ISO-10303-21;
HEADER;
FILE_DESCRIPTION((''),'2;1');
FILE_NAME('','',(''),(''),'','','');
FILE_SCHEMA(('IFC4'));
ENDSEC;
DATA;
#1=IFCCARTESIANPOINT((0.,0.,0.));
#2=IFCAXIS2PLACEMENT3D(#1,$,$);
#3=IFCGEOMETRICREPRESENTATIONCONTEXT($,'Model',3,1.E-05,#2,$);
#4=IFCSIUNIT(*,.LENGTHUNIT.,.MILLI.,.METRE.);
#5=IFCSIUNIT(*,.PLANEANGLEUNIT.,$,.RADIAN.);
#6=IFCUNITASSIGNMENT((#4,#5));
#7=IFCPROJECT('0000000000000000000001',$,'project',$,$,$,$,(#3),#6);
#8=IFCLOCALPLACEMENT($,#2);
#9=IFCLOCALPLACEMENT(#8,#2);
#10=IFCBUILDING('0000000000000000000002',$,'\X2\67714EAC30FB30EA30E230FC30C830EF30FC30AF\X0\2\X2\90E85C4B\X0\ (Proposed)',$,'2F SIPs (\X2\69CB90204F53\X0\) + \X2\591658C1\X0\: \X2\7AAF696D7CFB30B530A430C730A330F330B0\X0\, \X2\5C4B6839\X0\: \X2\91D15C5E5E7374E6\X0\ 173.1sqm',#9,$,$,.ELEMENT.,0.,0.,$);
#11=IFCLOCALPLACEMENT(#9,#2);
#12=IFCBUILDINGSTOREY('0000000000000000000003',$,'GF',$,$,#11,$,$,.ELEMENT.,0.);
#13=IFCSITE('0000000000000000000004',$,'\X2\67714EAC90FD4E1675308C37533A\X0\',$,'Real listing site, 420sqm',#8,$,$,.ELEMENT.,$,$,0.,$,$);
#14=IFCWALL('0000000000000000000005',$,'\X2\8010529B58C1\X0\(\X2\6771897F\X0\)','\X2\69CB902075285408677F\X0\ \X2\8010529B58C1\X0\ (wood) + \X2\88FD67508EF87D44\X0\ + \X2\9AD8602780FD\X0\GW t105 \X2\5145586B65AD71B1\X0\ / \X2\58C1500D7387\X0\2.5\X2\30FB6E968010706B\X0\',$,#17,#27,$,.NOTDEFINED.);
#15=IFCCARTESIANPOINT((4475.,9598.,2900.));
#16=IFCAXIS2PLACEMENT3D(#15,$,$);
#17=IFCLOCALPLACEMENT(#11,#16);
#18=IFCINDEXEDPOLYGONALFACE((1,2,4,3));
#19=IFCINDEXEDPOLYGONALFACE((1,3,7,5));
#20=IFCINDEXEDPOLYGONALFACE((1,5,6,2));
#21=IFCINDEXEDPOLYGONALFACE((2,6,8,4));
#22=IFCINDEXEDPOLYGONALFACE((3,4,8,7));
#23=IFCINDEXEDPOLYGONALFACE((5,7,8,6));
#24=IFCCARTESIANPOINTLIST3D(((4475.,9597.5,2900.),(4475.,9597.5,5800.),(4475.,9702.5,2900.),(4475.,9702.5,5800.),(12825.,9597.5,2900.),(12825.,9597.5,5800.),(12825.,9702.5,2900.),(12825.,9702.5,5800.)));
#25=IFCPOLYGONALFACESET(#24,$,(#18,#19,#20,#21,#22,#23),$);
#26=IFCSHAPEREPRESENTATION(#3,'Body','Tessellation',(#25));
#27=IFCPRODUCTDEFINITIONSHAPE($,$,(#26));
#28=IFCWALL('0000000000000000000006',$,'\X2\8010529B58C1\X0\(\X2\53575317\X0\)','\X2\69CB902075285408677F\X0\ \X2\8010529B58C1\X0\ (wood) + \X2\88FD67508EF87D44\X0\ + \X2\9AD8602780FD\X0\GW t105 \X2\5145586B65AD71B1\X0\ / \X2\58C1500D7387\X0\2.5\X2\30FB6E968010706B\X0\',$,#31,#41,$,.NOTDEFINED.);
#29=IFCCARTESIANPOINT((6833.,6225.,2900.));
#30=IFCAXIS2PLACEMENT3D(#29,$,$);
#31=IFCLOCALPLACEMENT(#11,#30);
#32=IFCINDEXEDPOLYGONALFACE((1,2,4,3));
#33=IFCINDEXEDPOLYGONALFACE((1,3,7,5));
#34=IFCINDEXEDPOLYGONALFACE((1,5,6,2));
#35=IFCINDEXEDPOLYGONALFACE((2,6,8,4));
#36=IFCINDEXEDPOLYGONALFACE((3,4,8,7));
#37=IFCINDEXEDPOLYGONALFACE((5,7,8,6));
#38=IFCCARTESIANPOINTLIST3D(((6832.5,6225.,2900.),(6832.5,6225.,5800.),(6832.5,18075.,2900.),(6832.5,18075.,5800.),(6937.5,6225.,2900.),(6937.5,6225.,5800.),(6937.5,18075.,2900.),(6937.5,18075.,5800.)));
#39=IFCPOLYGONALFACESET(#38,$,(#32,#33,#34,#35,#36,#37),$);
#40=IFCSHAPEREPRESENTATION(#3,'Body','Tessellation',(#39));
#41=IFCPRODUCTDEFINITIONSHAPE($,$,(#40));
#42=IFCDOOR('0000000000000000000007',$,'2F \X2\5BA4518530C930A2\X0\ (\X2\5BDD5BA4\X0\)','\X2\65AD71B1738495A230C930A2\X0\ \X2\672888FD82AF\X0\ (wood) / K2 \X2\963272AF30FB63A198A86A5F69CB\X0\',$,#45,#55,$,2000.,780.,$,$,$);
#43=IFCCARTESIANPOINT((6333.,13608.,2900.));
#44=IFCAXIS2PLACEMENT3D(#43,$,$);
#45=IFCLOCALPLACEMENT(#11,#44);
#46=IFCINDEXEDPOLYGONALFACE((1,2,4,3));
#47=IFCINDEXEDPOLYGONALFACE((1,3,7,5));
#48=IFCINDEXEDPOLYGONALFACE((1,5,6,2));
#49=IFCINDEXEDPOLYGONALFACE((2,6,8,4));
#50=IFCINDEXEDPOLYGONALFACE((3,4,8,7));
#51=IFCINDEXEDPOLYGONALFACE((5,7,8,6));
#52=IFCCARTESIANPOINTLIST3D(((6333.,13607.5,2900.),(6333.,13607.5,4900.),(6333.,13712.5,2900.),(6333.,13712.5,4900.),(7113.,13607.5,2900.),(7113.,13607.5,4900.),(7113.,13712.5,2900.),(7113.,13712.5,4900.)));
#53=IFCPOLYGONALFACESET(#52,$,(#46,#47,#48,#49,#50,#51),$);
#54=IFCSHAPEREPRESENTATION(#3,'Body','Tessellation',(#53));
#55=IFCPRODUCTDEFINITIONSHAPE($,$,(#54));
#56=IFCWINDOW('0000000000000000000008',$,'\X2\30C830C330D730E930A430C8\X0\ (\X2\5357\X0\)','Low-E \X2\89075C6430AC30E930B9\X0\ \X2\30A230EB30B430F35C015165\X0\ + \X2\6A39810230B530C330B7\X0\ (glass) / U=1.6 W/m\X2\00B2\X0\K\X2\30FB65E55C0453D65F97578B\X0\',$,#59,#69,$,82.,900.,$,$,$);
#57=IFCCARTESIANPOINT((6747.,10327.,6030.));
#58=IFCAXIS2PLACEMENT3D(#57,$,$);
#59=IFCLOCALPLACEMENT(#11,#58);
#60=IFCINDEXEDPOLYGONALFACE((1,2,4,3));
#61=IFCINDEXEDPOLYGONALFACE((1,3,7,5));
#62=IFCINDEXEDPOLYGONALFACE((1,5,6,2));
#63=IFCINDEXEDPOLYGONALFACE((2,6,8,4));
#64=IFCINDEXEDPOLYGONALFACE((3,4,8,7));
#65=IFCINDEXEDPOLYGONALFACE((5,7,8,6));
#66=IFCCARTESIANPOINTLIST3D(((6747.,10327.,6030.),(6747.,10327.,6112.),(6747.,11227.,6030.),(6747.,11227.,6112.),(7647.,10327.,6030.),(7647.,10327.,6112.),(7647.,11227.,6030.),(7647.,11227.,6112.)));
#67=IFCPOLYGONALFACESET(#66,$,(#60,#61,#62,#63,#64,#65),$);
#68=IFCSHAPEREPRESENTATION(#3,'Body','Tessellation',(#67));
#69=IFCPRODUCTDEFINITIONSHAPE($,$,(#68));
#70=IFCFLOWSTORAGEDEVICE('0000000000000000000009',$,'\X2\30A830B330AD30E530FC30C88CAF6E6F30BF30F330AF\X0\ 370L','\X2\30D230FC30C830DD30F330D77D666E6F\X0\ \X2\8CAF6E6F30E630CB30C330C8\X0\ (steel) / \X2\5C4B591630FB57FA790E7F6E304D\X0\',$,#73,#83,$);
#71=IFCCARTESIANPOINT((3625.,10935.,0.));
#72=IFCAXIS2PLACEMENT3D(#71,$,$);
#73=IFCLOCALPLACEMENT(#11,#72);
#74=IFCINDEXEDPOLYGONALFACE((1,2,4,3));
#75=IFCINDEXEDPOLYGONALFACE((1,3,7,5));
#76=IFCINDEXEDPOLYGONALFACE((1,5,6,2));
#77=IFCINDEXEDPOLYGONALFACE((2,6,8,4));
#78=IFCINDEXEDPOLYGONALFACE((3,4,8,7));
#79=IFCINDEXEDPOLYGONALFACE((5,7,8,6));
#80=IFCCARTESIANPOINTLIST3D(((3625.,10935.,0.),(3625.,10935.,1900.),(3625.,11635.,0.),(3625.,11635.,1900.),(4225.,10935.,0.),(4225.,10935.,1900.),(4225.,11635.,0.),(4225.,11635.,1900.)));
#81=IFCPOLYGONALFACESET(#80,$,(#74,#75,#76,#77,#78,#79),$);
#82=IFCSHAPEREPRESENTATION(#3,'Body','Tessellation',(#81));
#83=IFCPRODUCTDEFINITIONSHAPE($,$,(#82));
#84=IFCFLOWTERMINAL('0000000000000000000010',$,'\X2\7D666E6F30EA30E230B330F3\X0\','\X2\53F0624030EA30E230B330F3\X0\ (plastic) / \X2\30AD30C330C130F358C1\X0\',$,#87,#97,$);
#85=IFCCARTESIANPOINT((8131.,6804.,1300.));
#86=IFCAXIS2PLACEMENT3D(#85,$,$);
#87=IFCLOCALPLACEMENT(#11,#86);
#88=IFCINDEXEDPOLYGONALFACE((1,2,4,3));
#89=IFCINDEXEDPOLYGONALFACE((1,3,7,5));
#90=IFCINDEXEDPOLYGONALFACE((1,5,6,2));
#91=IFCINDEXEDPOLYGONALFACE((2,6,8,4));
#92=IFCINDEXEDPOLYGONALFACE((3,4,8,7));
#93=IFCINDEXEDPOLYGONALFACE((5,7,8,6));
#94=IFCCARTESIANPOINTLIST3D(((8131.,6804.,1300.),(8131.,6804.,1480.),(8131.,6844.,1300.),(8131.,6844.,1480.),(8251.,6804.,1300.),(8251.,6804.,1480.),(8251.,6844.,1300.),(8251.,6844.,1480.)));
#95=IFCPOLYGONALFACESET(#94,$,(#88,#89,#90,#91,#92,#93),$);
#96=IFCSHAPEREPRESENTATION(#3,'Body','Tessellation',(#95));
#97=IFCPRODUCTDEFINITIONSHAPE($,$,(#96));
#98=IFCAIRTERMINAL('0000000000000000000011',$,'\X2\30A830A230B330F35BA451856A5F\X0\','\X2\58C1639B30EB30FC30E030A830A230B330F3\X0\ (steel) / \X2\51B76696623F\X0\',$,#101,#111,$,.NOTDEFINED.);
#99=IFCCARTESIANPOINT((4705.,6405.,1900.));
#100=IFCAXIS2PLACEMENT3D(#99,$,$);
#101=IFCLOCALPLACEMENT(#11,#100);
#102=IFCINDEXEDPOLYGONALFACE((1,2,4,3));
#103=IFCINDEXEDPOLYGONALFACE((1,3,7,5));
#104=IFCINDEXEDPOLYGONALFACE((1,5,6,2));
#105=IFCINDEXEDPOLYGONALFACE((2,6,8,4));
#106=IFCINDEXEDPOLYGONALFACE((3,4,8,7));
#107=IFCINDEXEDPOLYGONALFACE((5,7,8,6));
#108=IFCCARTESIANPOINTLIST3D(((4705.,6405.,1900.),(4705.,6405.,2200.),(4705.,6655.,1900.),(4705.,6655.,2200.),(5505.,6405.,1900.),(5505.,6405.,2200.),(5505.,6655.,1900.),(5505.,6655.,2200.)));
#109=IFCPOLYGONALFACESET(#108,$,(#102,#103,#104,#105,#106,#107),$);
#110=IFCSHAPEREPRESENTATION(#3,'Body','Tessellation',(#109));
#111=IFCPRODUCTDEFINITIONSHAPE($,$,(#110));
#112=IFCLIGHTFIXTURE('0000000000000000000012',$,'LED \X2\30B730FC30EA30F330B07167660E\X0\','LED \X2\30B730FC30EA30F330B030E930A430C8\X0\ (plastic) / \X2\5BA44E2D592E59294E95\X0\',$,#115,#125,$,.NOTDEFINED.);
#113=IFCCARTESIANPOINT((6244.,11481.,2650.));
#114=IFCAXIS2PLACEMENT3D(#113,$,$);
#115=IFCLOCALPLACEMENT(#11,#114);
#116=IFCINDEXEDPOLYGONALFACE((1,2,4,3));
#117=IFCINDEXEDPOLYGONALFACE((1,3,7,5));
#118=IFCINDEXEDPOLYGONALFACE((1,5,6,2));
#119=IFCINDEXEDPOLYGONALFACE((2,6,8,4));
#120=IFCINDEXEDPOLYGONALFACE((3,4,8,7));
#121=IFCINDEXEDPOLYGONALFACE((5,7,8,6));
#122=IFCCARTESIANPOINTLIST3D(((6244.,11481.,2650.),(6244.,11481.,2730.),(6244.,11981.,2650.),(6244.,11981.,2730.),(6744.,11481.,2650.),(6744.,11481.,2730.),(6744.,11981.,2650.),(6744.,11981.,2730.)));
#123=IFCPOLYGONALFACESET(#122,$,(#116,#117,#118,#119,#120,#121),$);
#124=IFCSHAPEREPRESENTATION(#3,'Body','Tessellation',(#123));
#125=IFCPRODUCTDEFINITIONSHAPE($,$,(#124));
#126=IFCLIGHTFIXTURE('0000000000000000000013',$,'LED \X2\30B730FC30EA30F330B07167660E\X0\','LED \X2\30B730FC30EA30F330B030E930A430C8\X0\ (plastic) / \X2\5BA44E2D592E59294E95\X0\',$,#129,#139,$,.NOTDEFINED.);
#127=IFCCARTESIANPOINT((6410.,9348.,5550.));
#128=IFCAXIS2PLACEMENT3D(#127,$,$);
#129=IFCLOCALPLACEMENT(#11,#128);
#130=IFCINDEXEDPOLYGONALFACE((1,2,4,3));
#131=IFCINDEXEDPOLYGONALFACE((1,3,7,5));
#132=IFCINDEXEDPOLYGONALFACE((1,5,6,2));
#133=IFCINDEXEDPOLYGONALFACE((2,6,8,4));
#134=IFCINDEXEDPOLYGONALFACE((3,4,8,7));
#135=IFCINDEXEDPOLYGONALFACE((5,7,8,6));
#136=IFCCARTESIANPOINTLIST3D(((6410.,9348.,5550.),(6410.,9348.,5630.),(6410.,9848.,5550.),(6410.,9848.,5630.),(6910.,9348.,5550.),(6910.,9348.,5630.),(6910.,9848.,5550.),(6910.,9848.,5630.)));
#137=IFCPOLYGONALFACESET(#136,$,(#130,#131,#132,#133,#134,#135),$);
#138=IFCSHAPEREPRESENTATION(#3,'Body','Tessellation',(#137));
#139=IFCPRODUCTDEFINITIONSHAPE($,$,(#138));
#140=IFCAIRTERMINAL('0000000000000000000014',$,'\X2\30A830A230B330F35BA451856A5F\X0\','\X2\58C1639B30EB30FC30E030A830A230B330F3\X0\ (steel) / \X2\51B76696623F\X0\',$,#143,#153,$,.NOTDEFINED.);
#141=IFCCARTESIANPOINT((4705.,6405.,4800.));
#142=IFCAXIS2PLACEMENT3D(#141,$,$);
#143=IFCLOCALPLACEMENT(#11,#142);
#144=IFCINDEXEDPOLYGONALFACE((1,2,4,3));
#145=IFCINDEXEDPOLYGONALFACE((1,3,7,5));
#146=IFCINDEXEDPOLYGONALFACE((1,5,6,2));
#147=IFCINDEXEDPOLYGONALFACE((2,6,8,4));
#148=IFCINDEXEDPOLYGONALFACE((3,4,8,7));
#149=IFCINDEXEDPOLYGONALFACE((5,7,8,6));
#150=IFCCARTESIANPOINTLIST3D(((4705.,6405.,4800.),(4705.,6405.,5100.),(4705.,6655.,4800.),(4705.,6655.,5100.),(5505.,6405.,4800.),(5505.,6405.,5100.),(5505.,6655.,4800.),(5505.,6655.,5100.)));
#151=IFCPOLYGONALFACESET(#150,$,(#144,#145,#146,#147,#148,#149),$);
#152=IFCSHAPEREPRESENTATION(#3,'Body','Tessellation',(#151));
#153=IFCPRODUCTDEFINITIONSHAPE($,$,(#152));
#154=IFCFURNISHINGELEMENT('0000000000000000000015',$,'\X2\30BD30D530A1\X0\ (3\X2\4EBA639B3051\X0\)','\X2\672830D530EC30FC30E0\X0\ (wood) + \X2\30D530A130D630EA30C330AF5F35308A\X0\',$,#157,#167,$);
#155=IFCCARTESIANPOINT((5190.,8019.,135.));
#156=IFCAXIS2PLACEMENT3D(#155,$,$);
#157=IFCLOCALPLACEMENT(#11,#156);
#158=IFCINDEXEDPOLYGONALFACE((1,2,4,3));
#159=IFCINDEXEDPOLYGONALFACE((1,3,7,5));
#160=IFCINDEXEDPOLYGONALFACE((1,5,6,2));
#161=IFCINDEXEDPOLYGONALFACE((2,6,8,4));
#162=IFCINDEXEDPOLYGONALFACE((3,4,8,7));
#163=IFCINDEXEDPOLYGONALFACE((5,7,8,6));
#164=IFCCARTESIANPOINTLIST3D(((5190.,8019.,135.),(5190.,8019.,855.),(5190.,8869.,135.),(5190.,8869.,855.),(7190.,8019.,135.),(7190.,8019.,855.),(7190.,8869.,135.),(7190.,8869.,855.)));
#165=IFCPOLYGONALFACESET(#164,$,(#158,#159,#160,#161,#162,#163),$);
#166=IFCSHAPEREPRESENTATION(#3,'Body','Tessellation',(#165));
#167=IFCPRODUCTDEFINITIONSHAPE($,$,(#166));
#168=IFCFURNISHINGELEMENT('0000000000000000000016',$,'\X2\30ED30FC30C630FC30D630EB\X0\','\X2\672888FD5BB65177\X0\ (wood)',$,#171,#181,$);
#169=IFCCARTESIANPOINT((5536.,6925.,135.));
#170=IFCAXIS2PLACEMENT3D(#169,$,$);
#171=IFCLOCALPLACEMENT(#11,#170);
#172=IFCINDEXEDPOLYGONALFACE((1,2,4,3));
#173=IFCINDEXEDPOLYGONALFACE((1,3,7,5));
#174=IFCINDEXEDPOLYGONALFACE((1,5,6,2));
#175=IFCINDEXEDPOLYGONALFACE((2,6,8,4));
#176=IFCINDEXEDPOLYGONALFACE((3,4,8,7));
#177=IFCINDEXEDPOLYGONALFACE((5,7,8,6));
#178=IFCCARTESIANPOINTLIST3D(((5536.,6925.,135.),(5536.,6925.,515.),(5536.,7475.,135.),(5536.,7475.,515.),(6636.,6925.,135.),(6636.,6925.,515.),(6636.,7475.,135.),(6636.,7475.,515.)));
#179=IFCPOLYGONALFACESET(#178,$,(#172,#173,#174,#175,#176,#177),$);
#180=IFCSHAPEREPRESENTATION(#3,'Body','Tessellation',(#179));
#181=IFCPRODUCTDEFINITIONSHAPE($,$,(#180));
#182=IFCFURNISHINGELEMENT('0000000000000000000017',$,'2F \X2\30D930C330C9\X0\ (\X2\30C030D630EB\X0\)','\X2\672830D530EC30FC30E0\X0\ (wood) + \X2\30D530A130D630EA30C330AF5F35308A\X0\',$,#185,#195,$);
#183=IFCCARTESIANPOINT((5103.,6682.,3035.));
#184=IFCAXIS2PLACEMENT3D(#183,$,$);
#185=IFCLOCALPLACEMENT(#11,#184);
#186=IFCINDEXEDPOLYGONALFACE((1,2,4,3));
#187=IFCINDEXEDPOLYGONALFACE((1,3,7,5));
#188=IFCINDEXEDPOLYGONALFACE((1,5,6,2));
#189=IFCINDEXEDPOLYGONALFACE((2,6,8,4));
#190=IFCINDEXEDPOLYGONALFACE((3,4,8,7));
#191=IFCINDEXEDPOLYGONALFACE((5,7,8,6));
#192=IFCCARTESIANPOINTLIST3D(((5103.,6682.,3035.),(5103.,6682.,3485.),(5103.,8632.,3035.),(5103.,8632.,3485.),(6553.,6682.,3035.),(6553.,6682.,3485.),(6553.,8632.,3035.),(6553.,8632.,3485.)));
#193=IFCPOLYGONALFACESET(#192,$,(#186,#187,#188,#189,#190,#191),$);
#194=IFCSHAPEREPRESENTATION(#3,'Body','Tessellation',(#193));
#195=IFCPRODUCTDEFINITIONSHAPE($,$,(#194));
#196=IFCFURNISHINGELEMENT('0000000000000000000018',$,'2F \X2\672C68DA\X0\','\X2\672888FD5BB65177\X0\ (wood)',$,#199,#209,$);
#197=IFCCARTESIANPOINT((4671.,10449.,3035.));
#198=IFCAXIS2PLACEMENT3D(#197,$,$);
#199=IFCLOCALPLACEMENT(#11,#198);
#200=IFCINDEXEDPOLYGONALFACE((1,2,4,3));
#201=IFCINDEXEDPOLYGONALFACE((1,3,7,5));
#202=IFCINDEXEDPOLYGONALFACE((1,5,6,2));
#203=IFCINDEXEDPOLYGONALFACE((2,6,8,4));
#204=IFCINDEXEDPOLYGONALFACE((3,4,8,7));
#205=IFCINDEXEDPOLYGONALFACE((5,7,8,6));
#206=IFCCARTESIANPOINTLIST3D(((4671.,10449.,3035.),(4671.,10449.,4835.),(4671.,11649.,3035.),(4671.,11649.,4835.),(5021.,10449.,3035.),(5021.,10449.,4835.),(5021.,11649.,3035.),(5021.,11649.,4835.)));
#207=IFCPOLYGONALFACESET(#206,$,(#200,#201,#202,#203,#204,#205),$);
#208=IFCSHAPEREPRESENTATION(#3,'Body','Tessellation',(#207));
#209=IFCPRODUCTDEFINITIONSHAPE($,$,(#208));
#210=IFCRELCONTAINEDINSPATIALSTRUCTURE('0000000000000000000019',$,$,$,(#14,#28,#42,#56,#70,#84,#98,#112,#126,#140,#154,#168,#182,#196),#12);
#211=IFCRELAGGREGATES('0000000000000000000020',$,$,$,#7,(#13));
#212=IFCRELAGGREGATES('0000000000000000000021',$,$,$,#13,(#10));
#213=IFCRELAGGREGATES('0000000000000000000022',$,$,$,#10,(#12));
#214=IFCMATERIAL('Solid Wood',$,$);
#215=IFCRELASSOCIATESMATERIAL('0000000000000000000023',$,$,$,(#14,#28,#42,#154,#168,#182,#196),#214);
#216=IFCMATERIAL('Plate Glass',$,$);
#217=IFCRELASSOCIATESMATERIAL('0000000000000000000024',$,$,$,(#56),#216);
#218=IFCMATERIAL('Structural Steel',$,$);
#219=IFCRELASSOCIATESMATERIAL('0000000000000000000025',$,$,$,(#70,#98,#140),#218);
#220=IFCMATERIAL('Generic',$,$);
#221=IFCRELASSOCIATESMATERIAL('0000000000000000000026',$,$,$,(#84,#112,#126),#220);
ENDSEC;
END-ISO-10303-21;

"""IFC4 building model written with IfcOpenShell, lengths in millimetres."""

from ifc_helpers import new_model, si_unit, frame, frame_2d, origin, place, context, project, spatial, rectangle, extrude, material, element, fill, save


model = new_model("IFC4")

# Units and contexts
model_context = context("Model", 3, precision=1e-05, world=origin())
ifc_project = project(units=[si_unit("LENGTHUNIT", "METRE", prefix="MILLI"), si_unit("PLANEANGLEUNIT", "RADIAN")], contexts=[model_context])

# Site, building, storey
site_placement = place(None, origin())
site = spatial("IfcSite", under=ifc_project, at=site_placement, Name="東京都世田谷区", ObjectType="Real listing site, 420sqm", CompositionType="ELEMENT", RefElevation=0.0)
building_placement = place(site_placement, origin())
building = spatial("IfcBuilding", under=site, at=building_placement, Name="東京・リモートワーク2部屋 (Proposed)", ObjectType="2F SIPs (構造体) + 外壁: 窯業系サイディング, 屋根: 金属平瓦 173.1sqm", CompositionType="ELEMENT", ElevationOfRefHeight=0.0, ElevationOfTerrain=0.0)
storey_placement = place(building_placement, origin())
storey = spatial("IfcBuildingStorey", under=building, at=storey_placement, Name="GF", CompositionType="ELEMENT", Elevation=0.0)

# Shared definitions
ifc_material_1 = material(Name="Solid Wood")

# Wall
wall_1_placement = place(storey_placement, frame((4475.0, 9598.0, 2900.0)))
element("IfcWall", 1, at=wall_1_placement, inside=storey, material=ifc_material_1, Name="耐力壁(東西)", Description="構造用合板 耐力壁 (wood) + 製材軸組 + 高性能GW t105 充填断熱 / 壁倍率2.5・準耐火", PredefinedType="NOTDEFINED", context=model_context, shape_type="SweptSolid", body=[
    extrude(rectangle(XDim=8350.0, YDim=105.0, at=frame_2d((4175.0, 52.0))), frame((4475.0, 9598.0, 2900.0)), (0.0, 0.0, 1.0), 2900.0),
])

# Wall, opening, door
wall_2_placement = place(storey_placement, frame((6833.0, 6225.0, 2900.0)))
wall_2 = element("IfcWall", 2, at=wall_2_placement, inside=storey, material=ifc_material_1, Name="耐力壁(南北)", Description="構造用合板 耐力壁 (wood) + 製材軸組 + 高性能GW t105 充填断熱 / 壁倍率2.5・準耐火", PredefinedType="NOTDEFINED", context=model_context, shape_type="SweptSolid", body=[
    extrude(rectangle(XDim=105.0, YDim=11850.0, at=frame_2d((52.0, 5925.0))), frame((6833.0, 6225.0, 2900.0)), (0.0, 0.0, 1.0), 2900.0),
])
opening_placement = place(storey_placement, frame((6333.0, 13608.0, 2900.0)))
opening = element("IfcOpeningElement", 3, at=opening_placement, cuts=wall_2, PredefinedType="NOTDEFINED", context=model_context, shape_type="SweptSolid", body=[
    extrude(rectangle(XDim=780.0, YDim=105.0, at=frame_2d((390.0, 52.0))), frame((6333.0, 13608.0, 2900.0)), (0.0, 0.0, 1.0), 2000.0),
])
door_placement = place(storey_placement, frame((6333.0, 13608.0, 2900.0)))
door = element("IfcDoor", 4, at=door_placement, inside=storey, material=ifc_material_1, Name="2F 室内ドア (寝室)", Description="断熱玄関ドア 木製芯 (wood) / K2 防犯・採風機構", OverallHeight=2000.0, OverallWidth=780.0, context=model_context, shape_type="SweptSolid", body=[
    extrude(rectangle(XDim=780.0, YDim=105.0, at=frame_2d((390.0, 52.0))), frame((6333.0, 13608.0, 2900.0)), (0.0, 0.0, 1.0), 2000.0),
])
fill(opening, door)

# Window
ifc_material_2 = material(Name="Plate Glass")
window_placement = place(storey_placement, frame((6747.0, 10327.0, 6030.0)))
element("IfcWindow", 5, at=window_placement, inside=storey, material=ifc_material_2, Name="トップライト (南)", Description="Low-E 複層ガラス アルゴン封入 + 樹脂サッシ (glass) / U=1.6 W/m²K・日射取得型", OverallHeight=82.0, OverallWidth=900.0, context=model_context, shape_type="SweptSolid", body=[
    extrude(rectangle(XDim=900.0, YDim=900.0, at=frame_2d((450.0, 450.0))), frame((6747.0, 10327.0, 6030.0)), (0.0, 0.0, 1.0), 82.0),
])

# Flow storage device
ifc_material_3 = material(Name="Structural Steel")
flow_storage_device_placement = place(storey_placement, frame((3625.0, 10935.0, 0.0)))
element("IfcFlowStorageDevice", 6, at=flow_storage_device_placement, inside=storey, material=ifc_material_3, Name="エコキュート貯湯タンク 370L", Description="ヒートポンプ給湯 貯湯ユニット (steel) / 屋外・基礎置き", context=model_context, shape_type="SweptSolid", body=[
    extrude(rectangle(XDim=600.0, YDim=700.0, at=frame_2d((300.0, 350.0))), frame((3625.0, 10935.0, 0.0)), (0.0, 0.0, 1.0), 1900.0),
])

# Flow terminal
ifc_material_4 = material(Name="Generic")
flow_terminal_placement = place(storey_placement, frame((8131.0, 6804.0, 1300.0)))
element("IfcFlowTerminal", 7, at=flow_terminal_placement, inside=storey, material=ifc_material_4, Name="給湯リモコン", Description="台所リモコン (plastic) / キッチン壁", context=model_context, shape_type="SweptSolid", body=[
    extrude(rectangle(XDim=120.0, YDim=40.0, at=frame_2d((60.0, 20.0))), frame((8131.0, 6804.0, 1300.0)), (0.0, 0.0, 1.0), 180.0),
])

# Air terminal
air_terminal_1_placement = place(storey_placement, frame((4705.0, 6405.0, 1900.0)))
element("IfcAirTerminal", 8, at=air_terminal_1_placement, inside=storey, material=ifc_material_3, Name="エアコン室内機", Description="壁掛ルームエアコン (steel) / 冷暖房", PredefinedType="NOTDEFINED", context=model_context, shape_type="SweptSolid", body=[
    extrude(rectangle(XDim=800.0, YDim=250.0, at=frame_2d((400.0, 125.0))), frame((4705.0, 6405.0, 1900.0)), (0.0, 0.0, 1.0), 300.0),
])

# Light fixtures
light_fixture_1_placement = place(storey_placement, frame((6244.0, 11481.0, 2650.0)))
element("IfcLightFixture", 9, at=light_fixture_1_placement, inside=storey, material=ifc_material_4, Name="LED シーリング照明", Description="LED シーリングライト (plastic) / 室中央天井", PredefinedType="NOTDEFINED", context=model_context, shape_type="SweptSolid", body=[
    extrude(rectangle(XDim=500.0, YDim=500.0, at=frame_2d((250.0, 250.0))), frame((6244.0, 11481.0, 2650.0)), (0.0, 0.0, 1.0), 80.0),
])
light_fixture_2_placement = place(storey_placement, frame((6410.0, 9348.0, 5550.0)))
element("IfcLightFixture", 10, at=light_fixture_2_placement, inside=storey, material=ifc_material_4, Name="LED シーリング照明", Description="LED シーリングライト (plastic) / 室中央天井", PredefinedType="NOTDEFINED", context=model_context, shape_type="SweptSolid", body=[
    extrude(rectangle(XDim=500.0, YDim=500.0, at=frame_2d((250.0, 250.0))), frame((6410.0, 9348.0, 5550.0)), (0.0, 0.0, 1.0), 80.0),
])

# Air terminal
air_terminal_2_placement = place(storey_placement, frame((4705.0, 6405.0, 4800.0)))
element("IfcAirTerminal", 11, at=air_terminal_2_placement, inside=storey, material=ifc_material_3, Name="エアコン室内機", Description="壁掛ルームエアコン (steel) / 冷暖房", PredefinedType="NOTDEFINED", context=model_context, shape_type="SweptSolid", body=[
    extrude(rectangle(XDim=800.0, YDim=250.0, at=frame_2d((400.0, 125.0))), frame((4705.0, 6405.0, 4800.0)), (0.0, 0.0, 1.0), 300.0),
])

# Furnishing elements
furnishing_1_placement = place(storey_placement, frame((5190.0, 8019.0, 135.0)))
element("IfcFurnishingElement", 12, at=furnishing_1_placement, inside=storey, material=ifc_material_1, Name="ソファ (3人掛け)", Description="木フレーム (wood) + ファブリック張り", context=model_context, shape_type="SweptSolid", body=[
    extrude(rectangle(XDim=2000.0, YDim=850.0, at=frame_2d((1000.0, 425.0))), frame((5190.0, 8019.0, 135.0)), (0.0, 0.0, 1.0), 720.0),
])
furnishing_2_placement = place(storey_placement, frame((5536.0, 6925.0, 135.0)))
element("IfcFurnishingElement", 13, at=furnishing_2_placement, inside=storey, material=ifc_material_1, Name="ローテーブル", Description="木製家具 (wood)", context=model_context, shape_type="SweptSolid", body=[
    extrude(rectangle(XDim=1100.0, YDim=550.0, at=frame_2d((550.0, 275.0))), frame((5536.0, 6925.0, 135.0)), (0.0, 0.0, 1.0), 380.0),
])
furnishing_3_placement = place(storey_placement, frame((5103.0, 6682.0, 3035.0)))
element("IfcFurnishingElement", 14, at=furnishing_3_placement, inside=storey, material=ifc_material_1, Name="2F ベッド (ダブル)", Description="木フレーム (wood) + ファブリック張り", context=model_context, shape_type="SweptSolid", body=[
    extrude(rectangle(XDim=1450.0, YDim=1950.0, at=frame_2d((725.0, 975.0))), frame((5103.0, 6682.0, 3035.0)), (0.0, 0.0, 1.0), 450.0),
])
furnishing_4_placement = place(storey_placement, frame((4671.0, 10449.0, 3035.0)))
element("IfcFurnishingElement", 15, at=furnishing_4_placement, inside=storey, material=ifc_material_1, Name="2F 本棚", Description="木製家具 (wood)", context=model_context, shape_type="SweptSolid", body=[
    extrude(rectangle(XDim=350.0, YDim=1200.0, at=frame_2d((175.0, 600.0))), frame((4671.0, 10449.0, 3035.0)), (0.0, 0.0, 1.0), 1800.0),
])

save(model, "model.ifc")
